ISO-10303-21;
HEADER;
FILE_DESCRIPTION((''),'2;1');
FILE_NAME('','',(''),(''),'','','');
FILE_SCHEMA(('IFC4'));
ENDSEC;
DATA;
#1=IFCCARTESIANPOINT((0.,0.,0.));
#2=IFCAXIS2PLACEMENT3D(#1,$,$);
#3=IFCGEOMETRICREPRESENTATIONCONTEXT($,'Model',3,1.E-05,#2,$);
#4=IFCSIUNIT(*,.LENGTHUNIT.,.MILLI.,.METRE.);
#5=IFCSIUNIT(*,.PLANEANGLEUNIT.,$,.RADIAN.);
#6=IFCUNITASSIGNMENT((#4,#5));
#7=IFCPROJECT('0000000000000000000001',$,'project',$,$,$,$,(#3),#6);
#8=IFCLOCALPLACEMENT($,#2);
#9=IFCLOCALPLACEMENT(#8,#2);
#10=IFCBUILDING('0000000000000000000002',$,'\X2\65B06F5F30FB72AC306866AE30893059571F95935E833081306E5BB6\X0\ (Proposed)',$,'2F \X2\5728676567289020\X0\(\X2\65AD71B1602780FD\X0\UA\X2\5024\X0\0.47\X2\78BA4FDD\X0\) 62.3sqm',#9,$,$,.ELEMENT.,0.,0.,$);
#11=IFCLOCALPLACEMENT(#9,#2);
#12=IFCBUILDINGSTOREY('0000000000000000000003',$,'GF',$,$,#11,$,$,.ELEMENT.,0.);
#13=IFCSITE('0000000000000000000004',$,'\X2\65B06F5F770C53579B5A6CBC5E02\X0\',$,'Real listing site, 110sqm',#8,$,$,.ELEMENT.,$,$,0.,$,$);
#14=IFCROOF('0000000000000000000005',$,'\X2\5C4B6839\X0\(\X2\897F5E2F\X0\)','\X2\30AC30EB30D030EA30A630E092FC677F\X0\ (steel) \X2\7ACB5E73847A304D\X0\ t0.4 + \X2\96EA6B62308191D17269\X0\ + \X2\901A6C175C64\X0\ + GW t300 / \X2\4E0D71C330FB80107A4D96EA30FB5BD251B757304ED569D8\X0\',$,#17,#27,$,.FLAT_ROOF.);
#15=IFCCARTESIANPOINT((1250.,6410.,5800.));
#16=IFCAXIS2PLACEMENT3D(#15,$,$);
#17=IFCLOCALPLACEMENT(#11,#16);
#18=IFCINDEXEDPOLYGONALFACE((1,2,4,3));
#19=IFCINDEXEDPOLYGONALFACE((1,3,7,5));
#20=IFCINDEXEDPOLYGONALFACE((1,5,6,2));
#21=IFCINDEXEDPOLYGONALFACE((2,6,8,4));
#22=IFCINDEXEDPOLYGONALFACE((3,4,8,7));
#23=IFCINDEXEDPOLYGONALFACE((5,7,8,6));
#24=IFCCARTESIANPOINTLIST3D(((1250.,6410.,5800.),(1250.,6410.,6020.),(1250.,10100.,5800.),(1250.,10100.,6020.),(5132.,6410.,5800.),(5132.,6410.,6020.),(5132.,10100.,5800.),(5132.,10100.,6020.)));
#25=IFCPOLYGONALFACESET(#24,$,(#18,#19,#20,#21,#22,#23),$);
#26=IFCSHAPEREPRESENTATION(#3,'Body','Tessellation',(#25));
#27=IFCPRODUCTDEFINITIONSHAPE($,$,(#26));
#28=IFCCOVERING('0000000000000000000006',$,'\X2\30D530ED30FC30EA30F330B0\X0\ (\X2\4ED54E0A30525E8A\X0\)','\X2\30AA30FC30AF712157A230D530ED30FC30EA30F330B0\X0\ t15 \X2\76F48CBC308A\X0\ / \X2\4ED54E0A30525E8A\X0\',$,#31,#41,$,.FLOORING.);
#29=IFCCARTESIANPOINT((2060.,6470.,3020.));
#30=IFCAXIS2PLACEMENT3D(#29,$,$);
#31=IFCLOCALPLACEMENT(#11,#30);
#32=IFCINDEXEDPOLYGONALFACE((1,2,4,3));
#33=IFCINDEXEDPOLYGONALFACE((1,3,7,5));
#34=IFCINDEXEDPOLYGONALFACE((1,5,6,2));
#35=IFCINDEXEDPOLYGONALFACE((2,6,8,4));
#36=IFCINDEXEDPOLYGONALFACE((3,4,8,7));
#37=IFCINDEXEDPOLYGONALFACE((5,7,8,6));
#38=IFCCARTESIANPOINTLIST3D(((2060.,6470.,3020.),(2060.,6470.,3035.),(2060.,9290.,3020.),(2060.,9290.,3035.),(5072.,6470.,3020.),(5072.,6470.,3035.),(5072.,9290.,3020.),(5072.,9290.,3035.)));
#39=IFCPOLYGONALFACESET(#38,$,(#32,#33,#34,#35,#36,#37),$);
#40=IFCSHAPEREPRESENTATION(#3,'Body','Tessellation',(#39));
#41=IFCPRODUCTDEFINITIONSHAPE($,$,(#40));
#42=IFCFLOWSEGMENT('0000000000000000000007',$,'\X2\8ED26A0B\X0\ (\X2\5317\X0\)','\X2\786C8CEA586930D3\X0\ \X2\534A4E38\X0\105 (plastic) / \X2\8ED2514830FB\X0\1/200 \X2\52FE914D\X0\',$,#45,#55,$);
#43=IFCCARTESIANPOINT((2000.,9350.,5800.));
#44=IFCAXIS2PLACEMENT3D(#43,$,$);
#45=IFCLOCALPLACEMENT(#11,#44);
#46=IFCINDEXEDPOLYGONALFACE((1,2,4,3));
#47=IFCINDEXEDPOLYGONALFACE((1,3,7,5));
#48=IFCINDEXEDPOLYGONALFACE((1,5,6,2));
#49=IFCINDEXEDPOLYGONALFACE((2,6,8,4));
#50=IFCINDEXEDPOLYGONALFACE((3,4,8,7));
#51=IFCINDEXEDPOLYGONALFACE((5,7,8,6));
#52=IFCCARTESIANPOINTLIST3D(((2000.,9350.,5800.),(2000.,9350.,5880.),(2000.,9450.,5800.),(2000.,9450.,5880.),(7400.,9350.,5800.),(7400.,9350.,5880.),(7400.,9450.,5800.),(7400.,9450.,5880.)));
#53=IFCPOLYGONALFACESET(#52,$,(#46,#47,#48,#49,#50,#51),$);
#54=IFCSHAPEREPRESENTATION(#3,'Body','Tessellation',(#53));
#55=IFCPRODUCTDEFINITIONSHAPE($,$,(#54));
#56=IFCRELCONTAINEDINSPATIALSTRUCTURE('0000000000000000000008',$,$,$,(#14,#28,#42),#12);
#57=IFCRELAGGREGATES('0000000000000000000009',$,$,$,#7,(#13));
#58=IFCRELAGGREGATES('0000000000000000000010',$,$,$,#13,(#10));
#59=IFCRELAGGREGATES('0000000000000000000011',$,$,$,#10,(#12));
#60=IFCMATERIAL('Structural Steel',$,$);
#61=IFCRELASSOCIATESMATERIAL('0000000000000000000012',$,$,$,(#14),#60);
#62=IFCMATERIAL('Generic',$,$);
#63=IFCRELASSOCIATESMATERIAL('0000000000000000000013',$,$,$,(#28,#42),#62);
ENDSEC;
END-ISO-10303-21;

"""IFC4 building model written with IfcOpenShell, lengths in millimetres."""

from ifc_helpers import new_model, si_unit, frame, frame_2d, origin, place, context, project, spatial, rectangle, extrude, material, element, save


model = new_model("IFC4")

# Units and contexts
model_context = context("Model", 3, precision=1e-05, world=origin())
ifc_project = project(units=[si_unit("LENGTHUNIT", "METRE", prefix="MILLI"), si_unit("PLANEANGLEUNIT", "RADIAN")], contexts=[model_context])

# Site, building, storey
site_placement = place(None, origin())
site = spatial("IfcSite", under=ifc_project, at=site_placement, Name="新潟県南魚沼市", ObjectType="Real listing site, 110sqm", CompositionType="ELEMENT", RefElevation=0.0)
building_placement = place(site_placement, origin())
building = spatial("IfcBuilding", under=site, at=building_placement, Name="新潟・犬と暮らす土間広めの家 (Proposed)", ObjectType="2F 在来木造(断熱性能UA値0.47確保) 62.3sqm", CompositionType="ELEMENT", ElevationOfRefHeight=0.0, ElevationOfTerrain=0.0)
storey_placement = place(building_placement, origin())
storey = spatial("IfcBuildingStorey", under=building, at=storey_placement, Name="GF", CompositionType="ELEMENT", Elevation=0.0)

# Roof
ifc_material_1 = material(Name="Structural Steel")
for number, where, name in (
    (1, (1250.0, 6410.0, 5800.0), "屋根(西帯)"),
):
    element("IfcRoof", number, at=place(storey_placement, frame(where)), inside=storey, material=ifc_material_1, Name=name, Description="ガルバリウム鋼板 (steel) 立平葺き t0.4 + 雪止め金物 + 通気層 + GW t300 / 不燃・耐積雪・寒冷地仕様", PredefinedType="FLAT_ROOF", context=model_context, shape_type="SweptSolid", body=[
        extrude(rectangle(XDim=3882.0, YDim=3690.0, at=frame_2d((1941.0, 1845.0))), frame((1250.0, 6410.0, 5800.0)), (0.0, 0.0, 1.0), 220.0),
    ])

# Covering
ifc_material_2 = material(Name="Generic")
covering_placement = place(storey_placement, frame((2060.0, 6470.0, 3020.0)))
element("IfcCovering", 2, at=covering_placement, inside=storey, material=ifc_material_2, Name="フローリング (仕上げ床)", Description="オーク無垢フローリング t15 直貼り / 仕上げ床", PredefinedType="FLOORING", context=model_context, shape_type="SweptSolid", body=[
    extrude(rectangle(XDim=3012.0, YDim=2820.0, at=frame_2d((1506.0, 1410.0))), frame((2060.0, 6470.0, 3020.0)), (0.0, 0.0, 1.0), 15.0),
])

# Flow segment
flow_segment_placement = place(storey_placement, frame((2000.0, 9350.0, 5800.0)))
element("IfcFlowSegment", 3, at=flow_segment_placement, inside=storey, material=ifc_material_2, Name="軒樋 (北)", Description="硬質塩ビ 半丸105 (plastic) / 軒先・1/200 勾配", context=model_context, shape_type="SweptSolid", body=[
    extrude(rectangle(XDim=5400.0, YDim=100.0, at=frame_2d((2700.0, 50.0))), frame((2000.0, 9350.0, 5800.0)), (0.0, 0.0, 1.0), 80.0),
])

save(model, "model.ifc")
